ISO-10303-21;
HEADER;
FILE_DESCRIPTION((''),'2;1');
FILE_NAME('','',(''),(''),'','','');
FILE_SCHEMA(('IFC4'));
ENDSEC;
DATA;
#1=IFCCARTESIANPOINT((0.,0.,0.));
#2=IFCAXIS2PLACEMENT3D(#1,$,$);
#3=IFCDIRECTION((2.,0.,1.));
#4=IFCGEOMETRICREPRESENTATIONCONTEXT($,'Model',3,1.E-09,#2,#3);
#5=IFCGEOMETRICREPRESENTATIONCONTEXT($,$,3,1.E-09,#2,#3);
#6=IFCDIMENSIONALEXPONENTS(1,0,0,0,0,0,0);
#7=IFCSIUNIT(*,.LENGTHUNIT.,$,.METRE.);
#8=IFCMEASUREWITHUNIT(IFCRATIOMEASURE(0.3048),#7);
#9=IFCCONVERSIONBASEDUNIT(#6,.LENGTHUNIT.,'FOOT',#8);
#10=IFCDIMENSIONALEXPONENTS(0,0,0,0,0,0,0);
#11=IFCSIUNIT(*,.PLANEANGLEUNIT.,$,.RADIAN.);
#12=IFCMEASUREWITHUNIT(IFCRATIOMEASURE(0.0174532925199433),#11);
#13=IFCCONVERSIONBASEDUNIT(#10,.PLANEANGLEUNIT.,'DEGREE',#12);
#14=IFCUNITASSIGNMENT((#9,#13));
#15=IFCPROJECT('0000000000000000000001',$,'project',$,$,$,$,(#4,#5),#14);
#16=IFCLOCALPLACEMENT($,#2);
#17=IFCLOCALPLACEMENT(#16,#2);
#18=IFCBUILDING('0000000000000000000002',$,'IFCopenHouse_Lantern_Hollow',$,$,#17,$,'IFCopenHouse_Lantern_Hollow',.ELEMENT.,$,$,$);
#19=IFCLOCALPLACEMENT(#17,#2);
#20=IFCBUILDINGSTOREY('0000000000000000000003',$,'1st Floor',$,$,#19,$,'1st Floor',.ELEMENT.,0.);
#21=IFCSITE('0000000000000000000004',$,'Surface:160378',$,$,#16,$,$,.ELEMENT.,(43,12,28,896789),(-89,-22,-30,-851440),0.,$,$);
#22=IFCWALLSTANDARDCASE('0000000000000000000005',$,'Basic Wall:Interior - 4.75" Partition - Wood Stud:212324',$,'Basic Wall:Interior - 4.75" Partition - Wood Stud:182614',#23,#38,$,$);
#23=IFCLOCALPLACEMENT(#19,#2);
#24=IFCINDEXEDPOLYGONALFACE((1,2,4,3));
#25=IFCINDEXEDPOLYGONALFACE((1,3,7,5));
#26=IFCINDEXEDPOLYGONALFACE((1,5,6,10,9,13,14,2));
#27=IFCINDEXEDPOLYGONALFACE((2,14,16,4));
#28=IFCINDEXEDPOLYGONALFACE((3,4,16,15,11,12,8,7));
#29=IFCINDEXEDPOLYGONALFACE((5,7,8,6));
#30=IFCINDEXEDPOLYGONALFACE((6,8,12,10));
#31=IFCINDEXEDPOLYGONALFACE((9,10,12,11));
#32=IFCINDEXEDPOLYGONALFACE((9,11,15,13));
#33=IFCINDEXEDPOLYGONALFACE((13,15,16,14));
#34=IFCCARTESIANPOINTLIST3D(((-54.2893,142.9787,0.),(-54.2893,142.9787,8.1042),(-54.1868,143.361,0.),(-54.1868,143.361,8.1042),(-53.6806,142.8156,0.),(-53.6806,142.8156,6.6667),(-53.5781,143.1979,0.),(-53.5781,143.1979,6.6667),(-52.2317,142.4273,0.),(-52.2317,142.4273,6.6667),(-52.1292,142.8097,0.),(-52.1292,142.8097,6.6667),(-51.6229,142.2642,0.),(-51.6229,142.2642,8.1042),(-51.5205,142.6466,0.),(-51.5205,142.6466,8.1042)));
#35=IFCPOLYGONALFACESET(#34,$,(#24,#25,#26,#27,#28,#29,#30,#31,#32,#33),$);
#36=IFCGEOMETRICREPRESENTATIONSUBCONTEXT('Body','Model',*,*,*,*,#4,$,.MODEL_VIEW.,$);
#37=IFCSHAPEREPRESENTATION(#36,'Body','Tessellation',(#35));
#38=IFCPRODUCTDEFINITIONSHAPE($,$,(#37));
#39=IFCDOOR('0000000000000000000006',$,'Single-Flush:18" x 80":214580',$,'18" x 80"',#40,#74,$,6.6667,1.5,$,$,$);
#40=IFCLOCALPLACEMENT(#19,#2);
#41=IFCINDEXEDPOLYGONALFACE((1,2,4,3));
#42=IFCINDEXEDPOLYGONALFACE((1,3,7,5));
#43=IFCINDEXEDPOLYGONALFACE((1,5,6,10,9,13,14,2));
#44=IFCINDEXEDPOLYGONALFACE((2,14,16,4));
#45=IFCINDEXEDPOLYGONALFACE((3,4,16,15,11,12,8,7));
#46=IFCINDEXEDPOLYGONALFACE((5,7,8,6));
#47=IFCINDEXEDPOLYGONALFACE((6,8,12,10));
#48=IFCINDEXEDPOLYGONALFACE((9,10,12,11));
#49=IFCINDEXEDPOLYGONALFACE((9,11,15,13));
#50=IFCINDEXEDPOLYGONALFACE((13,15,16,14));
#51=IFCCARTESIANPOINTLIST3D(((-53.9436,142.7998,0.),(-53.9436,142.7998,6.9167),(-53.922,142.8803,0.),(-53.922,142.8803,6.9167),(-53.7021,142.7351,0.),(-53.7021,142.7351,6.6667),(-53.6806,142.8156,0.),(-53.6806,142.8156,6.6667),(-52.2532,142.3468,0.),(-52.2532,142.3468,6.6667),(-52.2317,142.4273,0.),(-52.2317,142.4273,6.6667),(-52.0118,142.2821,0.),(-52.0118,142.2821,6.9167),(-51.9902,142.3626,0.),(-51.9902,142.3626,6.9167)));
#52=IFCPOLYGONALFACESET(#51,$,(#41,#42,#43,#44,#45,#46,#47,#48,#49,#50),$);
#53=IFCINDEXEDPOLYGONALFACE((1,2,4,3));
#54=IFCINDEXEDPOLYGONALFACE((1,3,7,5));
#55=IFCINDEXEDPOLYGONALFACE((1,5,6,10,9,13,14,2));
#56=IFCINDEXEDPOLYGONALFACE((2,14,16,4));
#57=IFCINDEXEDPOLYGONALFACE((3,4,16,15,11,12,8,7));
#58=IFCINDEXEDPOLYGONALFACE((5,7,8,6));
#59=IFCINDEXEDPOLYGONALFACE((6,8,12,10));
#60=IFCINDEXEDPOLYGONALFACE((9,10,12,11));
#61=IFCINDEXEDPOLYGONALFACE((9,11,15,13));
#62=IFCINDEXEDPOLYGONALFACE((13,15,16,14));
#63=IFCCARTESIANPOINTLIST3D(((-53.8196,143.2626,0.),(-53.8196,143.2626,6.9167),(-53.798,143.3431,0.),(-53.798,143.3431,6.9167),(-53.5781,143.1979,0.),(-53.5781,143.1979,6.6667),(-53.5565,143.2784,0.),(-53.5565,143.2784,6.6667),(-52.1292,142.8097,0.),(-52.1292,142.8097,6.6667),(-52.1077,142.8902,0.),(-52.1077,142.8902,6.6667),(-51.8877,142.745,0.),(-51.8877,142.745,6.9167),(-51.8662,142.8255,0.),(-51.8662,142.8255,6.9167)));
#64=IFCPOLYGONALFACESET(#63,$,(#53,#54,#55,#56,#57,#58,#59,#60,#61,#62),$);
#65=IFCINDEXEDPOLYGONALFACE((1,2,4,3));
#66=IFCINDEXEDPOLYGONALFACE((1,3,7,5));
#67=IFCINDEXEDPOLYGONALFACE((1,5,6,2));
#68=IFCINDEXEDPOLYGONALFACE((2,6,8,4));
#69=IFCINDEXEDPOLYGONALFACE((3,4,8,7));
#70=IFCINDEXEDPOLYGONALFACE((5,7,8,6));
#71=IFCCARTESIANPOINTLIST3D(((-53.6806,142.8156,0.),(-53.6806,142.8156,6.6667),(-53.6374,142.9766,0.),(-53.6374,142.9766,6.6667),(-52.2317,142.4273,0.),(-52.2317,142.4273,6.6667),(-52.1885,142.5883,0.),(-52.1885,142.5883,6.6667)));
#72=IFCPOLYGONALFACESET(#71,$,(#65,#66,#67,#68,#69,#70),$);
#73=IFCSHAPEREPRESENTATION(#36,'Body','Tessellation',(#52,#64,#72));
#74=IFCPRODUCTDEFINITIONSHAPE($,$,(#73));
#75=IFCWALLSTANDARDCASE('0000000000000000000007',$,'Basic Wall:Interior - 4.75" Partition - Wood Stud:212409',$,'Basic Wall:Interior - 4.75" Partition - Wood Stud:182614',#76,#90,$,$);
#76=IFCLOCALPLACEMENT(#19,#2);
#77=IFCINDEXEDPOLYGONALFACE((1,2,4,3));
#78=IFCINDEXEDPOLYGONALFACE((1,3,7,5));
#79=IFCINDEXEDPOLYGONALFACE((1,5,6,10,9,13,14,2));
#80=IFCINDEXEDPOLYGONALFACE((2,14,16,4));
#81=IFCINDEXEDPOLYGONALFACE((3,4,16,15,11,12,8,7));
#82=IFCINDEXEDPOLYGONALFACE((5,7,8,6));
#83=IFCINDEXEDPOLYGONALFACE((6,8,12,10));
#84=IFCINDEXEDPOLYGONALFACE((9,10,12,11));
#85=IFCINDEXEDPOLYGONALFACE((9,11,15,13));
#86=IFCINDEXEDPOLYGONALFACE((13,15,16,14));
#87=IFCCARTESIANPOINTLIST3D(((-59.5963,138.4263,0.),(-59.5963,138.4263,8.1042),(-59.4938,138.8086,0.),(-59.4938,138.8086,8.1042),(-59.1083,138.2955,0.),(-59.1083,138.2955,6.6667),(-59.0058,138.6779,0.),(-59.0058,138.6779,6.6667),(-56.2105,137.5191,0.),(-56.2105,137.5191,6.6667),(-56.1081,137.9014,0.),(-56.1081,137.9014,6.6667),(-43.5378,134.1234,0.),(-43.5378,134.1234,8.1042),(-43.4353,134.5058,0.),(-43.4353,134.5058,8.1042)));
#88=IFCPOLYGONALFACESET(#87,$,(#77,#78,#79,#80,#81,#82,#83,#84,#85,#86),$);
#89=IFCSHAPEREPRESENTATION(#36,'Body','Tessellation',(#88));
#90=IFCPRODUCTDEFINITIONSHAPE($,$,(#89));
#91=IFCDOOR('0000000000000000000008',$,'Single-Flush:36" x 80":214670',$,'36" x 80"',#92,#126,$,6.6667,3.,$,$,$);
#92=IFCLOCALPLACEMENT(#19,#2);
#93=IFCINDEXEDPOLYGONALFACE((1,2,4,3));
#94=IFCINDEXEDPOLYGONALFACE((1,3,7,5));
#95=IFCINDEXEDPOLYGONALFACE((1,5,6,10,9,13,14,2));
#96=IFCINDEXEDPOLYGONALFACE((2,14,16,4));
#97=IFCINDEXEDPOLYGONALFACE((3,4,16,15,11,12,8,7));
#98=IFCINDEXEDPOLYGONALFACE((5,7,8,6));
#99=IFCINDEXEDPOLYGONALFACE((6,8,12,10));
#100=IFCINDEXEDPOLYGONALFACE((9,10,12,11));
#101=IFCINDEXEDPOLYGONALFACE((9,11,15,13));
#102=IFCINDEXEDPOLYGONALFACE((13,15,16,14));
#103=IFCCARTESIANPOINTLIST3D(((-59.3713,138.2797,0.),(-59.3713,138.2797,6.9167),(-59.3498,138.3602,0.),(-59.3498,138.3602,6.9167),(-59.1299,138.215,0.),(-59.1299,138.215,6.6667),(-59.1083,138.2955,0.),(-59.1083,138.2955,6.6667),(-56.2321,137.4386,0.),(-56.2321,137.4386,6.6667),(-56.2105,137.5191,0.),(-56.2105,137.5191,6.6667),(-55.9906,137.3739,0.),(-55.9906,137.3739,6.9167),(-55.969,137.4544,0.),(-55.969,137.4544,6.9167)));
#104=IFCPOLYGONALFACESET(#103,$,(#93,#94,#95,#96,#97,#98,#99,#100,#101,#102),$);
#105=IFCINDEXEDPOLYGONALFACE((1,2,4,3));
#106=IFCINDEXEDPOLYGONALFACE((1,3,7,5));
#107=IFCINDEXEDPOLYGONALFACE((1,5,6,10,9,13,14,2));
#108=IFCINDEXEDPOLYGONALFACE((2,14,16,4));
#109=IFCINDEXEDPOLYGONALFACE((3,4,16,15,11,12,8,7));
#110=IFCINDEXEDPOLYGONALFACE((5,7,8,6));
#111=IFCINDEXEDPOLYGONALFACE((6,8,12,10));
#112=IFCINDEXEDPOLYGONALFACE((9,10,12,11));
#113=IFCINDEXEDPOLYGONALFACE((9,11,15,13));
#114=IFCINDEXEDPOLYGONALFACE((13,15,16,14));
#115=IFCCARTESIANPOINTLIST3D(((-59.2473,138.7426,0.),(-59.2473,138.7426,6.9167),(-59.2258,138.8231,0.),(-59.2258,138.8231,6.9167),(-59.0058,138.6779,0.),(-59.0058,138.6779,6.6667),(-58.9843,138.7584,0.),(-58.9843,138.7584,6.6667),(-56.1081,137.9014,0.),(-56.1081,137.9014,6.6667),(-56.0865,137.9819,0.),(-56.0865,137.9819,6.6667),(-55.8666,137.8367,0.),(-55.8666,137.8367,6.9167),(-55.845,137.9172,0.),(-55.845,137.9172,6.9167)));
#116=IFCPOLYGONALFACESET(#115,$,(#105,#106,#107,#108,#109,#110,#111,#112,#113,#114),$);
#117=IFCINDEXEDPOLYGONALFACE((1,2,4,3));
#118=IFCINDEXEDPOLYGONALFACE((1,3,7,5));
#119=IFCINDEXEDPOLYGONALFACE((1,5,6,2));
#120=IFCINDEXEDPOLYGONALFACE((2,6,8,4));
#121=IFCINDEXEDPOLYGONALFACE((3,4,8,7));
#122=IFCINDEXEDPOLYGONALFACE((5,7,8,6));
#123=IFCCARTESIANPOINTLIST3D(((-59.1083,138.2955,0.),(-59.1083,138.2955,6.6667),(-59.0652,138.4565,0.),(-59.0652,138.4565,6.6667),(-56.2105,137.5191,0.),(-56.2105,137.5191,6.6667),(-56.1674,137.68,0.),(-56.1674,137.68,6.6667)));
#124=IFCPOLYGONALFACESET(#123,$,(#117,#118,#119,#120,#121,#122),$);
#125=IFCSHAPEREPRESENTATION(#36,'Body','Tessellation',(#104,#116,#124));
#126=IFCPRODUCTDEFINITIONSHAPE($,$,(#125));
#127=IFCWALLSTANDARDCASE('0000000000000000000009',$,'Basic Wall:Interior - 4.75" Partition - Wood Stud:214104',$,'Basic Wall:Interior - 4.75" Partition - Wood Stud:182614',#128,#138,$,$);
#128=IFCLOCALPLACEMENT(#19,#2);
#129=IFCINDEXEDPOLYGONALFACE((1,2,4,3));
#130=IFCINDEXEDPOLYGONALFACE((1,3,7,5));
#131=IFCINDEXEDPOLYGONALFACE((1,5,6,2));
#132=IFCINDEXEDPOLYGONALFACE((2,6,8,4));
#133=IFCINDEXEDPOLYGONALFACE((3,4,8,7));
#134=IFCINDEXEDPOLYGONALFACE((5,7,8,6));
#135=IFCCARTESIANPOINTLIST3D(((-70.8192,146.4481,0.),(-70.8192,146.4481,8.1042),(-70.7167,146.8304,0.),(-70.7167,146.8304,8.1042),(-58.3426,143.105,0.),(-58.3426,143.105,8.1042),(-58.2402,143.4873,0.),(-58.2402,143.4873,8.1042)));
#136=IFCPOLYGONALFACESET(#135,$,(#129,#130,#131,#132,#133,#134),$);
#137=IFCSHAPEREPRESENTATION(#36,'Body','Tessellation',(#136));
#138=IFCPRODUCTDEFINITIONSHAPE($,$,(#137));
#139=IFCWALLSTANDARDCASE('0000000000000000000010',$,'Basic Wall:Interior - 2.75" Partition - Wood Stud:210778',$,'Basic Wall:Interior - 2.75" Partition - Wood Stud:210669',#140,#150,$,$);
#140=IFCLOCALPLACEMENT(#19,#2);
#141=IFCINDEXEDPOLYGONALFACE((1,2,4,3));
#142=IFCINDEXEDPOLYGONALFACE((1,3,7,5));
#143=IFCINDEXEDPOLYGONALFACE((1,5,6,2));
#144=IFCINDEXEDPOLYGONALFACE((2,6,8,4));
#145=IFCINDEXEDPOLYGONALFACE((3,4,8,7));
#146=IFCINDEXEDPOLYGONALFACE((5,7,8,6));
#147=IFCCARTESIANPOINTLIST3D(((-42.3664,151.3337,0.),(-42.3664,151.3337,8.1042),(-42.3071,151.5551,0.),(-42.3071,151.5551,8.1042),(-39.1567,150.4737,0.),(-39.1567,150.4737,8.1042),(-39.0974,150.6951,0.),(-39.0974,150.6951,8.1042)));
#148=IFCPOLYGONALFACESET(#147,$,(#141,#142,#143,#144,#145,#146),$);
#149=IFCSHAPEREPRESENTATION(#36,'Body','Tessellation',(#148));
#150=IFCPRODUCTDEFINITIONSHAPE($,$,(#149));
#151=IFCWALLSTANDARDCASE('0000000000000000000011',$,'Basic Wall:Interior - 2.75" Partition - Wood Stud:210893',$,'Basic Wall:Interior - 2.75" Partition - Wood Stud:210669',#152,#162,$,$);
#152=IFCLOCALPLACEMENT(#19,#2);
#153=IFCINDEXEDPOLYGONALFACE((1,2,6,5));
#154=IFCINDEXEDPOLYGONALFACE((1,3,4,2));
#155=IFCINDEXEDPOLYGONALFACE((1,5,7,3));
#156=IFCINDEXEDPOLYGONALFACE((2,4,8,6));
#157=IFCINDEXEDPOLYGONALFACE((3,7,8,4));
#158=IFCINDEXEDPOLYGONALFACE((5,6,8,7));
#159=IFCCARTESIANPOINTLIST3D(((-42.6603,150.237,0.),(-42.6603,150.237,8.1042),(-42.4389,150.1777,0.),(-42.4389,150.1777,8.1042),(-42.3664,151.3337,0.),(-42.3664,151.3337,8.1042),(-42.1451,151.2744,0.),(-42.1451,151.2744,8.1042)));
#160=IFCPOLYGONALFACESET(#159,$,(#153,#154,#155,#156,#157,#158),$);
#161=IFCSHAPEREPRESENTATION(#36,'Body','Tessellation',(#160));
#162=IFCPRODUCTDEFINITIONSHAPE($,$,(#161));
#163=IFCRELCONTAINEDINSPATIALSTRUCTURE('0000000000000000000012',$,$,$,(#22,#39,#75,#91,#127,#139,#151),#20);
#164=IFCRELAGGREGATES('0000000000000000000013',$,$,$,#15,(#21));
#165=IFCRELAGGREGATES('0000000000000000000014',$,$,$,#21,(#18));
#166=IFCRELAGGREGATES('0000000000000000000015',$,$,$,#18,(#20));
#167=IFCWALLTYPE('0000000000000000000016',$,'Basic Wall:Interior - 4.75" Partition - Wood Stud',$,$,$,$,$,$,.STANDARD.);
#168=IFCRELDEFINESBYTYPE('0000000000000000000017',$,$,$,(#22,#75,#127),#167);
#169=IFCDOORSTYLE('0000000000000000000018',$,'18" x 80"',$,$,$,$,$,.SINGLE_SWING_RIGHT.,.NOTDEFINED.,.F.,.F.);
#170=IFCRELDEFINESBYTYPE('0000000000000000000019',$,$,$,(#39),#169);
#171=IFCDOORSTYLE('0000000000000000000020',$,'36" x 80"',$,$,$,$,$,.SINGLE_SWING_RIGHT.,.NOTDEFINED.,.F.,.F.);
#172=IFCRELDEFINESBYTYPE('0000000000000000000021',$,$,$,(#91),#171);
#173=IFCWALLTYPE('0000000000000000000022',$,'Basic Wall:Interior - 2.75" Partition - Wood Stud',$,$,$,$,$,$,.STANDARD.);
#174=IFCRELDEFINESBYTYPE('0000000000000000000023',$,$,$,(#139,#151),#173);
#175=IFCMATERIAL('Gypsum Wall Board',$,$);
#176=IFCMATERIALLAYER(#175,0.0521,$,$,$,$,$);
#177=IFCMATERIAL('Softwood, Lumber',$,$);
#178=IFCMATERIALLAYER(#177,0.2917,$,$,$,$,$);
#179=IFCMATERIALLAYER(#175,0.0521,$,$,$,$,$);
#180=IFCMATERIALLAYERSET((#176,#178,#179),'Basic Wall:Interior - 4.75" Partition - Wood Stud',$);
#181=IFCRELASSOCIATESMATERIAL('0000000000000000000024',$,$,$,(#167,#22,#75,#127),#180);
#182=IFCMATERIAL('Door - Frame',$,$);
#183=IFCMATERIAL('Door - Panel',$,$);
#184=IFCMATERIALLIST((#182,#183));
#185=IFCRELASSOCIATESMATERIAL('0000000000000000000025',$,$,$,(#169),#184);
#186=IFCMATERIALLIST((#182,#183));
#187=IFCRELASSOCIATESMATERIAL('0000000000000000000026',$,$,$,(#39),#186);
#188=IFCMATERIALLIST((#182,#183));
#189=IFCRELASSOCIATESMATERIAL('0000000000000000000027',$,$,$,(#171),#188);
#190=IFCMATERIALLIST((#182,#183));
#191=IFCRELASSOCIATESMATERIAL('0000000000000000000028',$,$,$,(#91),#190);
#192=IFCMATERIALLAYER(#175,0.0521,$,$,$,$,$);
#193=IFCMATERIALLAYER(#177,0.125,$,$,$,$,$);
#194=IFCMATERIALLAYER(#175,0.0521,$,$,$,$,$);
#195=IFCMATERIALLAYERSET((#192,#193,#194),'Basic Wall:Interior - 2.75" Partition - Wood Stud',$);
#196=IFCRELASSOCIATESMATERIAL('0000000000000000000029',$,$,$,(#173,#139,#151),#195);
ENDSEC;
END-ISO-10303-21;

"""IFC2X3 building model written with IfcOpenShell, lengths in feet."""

from ifc_helpers import new_model, entity, si_unit, converted_unit, direction, frame, frame_2d, origin, place, context, subcontext, project, spatial, polyline, rectangle, outline, extrude, source, transform, mapped, material, material_list, layer, layer_set, layer_usage, type_object, type_shapes, element, fill, save


model = new_model("IFC2X3")

# Units and contexts
model_context = context("Model", 3, precision=1e-09, world=origin(), true_north=direction((2.0, 0.0, 1.0)))
context_of_model = context(None, 3, precision=1e-09, world=origin(), true_north=direction((2.0, 0.0, 1.0)))
body_context = subcontext(model_context, "Body", "Model", "MODEL_VIEW")
ifc_project = project(units=[converted_unit("LENGTHUNIT", "FOOT", entity("IfcRatioMeasure", 0.3048), si_unit("LENGTHUNIT", "METRE"), dimensions=[1, 0, 0, 0, 0, 0, 0]), converted_unit("PLANEANGLEUNIT", "DEGREE", entity("IfcRatioMeasure", 0.0174532925199433), si_unit("PLANEANGLEUNIT", "RADIAN"), dimensions=[0, 0, 0, 0, 0, 0, 0])], contexts=[model_context, context_of_model])

# Site, building, storey
site_placement = place(None, origin())
site = spatial("IfcSite", under=ifc_project, at=site_placement, Name="Surface:160378", CompositionType="ELEMENT", RefLatitude=(43, 12, 28, 896789), RefLongitude=(-89, -22, -30, -851440), RefElevation=0.0)
building_placement = place(site_placement, origin())
building = spatial("IfcBuilding", under=site, at=building_placement, Name="IFCopenHouse_Lantern_Hollow", LongName="IFCopenHouse_Lantern_Hollow", CompositionType="ELEMENT")
storey_placement = place(building_placement, origin())
storey = spatial("IfcBuildingStorey", under=building, at=storey_placement, Name="1st Floor", LongName="1st Floor", CompositionType="ELEMENT", Elevation=0.0)

# Shared definitions
ifc_material_1 = material(Name="Gypsum Wall Board")
ifc_layer_1 = layer(ifc_material_1, 0.0521)
ifc_material_2 = material(Name="Softwood, Lumber")
ifc_layer_2 = layer(ifc_material_2, 0.2917)
ifc_layer_3 = layer(ifc_material_1, 0.0521)
ifc_layer_set_1 = layer_set([ifc_layer_1, ifc_layer_2, ifc_layer_3], Name="Basic Wall:Interior - 4.75\" Partition - Wood Stud")
wall_type_1 = type_object("IfcWallType", Name="Basic Wall:Interior - 4.75\" Partition - Wood Stud", PredefinedType="STANDARD", material=ifc_layer_set_1)

# Shared definitions
ifc_material_3 = material(Name="Door - Panel")
ifc_material_4 = material(Name="Door - Frame")

# Walls, openings, doors
ifc_layer_usage_1 = layer_usage(ifc_layer_set_1, "AXIS2", "NEGATIVE", 0.1979)
wall_1_placement = place(storey_placement, frame((-51.5717, 142.4554, 0.0), z_axis=(0.0, 0.0, 1.0), x_axis=(-0.965926, 0.258819, 0.0)))
wall_1 = element("IfcWallStandardCase", 1, at=wall_1_placement, inside=storey, type_object=wall_type_1, material=ifc_layer_usage_1, Name="Basic Wall:Interior - 4.75\" Partition - Wood Stud:212324", ObjectType="Basic Wall:Interior - 4.75\" Partition - Wood Stud:182614", context=body_context, shape_type="SweptSolid", body=[
    extrude(rectangle(XDim=2.7604, YDim=0.3958, at=frame_2d((1.3802, 0.0), x_axis=(-1.0, 0.0))), origin(), (0.0, 0.0, 1.0), 8.1042),
])
opening_1_placement = place(wall_1_placement, frame((0.6302, -0.1979, 0.0)))
opening_1 = element("IfcOpeningElement", 2, at=opening_1_placement, cuts=wall_1, ObjectType="Opening", context=body_context, shape_type="SweptSolid", body=[
    extrude(rectangle(XDim=1.5, YDim=6.6667, at=frame_2d((3.3333, 0.75), x_axis=(0.0, 1.0))), frame((0.0, 0.0, 0.0), z_axis=(0.0, 1.0, 0.0), x_axis=(0.0, 0.0, 1.0)), (0.0, 0.0, 1.0), 0.3958),
])
ifc_material_list_1 = material_list([ifc_material_4, ifc_material_3])
ifc_material_list_2 = material_list([ifc_material_4, ifc_material_3])
door_style_1 = type_object("IfcDoorStyle", Name="18\" x 80\"", ConstructionType="NOTDEFINED", OperationType="SINGLE_SWING_RIGHT", ParameterTakesPrecedence=False, Sizeable=False, material=ifc_material_list_2)
shared_shape_1 = source(origin(), body_context, "Body", "SweptSolid", [
    extrude(outline(polyline([(-1.0, -3.5208), (1.0, -3.5208), (1.0, 3.3958), (0.75, 3.3958), (0.75, -3.2708), (-0.75, -3.2708), (-0.75, 3.3958), (-1.0, 3.3958), (-1.0, -3.5208)])), frame((0.75, 0.3958, 3.3958), z_axis=(0.0, 1.0, 0.0), x_axis=(1.0, 0.0, 0.0)), (0.0, 0.0, 1.0), 0.0833),
    extrude(outline(polyline([(-3.5208, -1.0), (3.3958, -1.0), (3.3958, -0.75), (-3.2708, -0.75), (-3.2708, 0.75), (3.3958, 0.75), (3.3958, 1.0), (-3.5208, 1.0), (-3.5208, -1.0)])), frame((0.75, -0.0833, 3.3958), z_axis=(0.0, 1.0, 0.0), x_axis=(0.0, 0.0, -1.0)), (0.0, 0.0, 1.0), 0.0833),
    extrude(rectangle(XDim=0.1667, YDim=1.5, at=frame_2d((0.0, 0.0), x_axis=(1.0, 0.0))), frame((0.75, 0.3125, 0.0), z_axis=(0.0, 0.0, 1.0), x_axis=(0.0, 1.0, 0.0)), (0.0, 0.0, 1.0), 6.6667),
])
type_shapes(door_style_1, [shared_shape_1])
door_1_placement = place(storey_placement, frame((-52.1292, 142.8097, 0.0), z_axis=(0.0, 0.0, 1.0), x_axis=(-0.965926, 0.258819, 0.0)))
door_1 = element("IfcDoor", 3, at=door_1_placement, inside=storey, type_object=door_style_1, material=ifc_material_list_1, Name="Single-Flush:18\" x 80\":214580", ObjectType="18\" x 80\"", OverallHeight=6.6667, OverallWidth=1.5, context=body_context, shape_type="MappedRepresentation", body=[
    mapped(shared_shape_1, transform((0.0, 0.0, 0.0), scale=1.0)),
])
fill(opening_1, door_1)
ifc_layer_usage_2 = layer_usage(ifc_layer_set_1, "AXIS2", "NEGATIVE", 0.1979)
wall_2_placement = place(storey_placement, frame((-43.4865, 134.3146, 0.0), z_axis=(0.0, 0.0, 1.0), x_axis=(-0.965926, 0.258819, 0.0)))
wall_2 = element("IfcWallStandardCase", 4, at=wall_2_placement, inside=storey, type_object=wall_type_1, material=ifc_layer_usage_2, Name="Basic Wall:Interior - 4.75\" Partition - Wood Stud:212409", ObjectType="Basic Wall:Interior - 4.75\" Partition - Wood Stud:182614", context=body_context, shape_type="SweptSolid", body=[
    extrude(rectangle(XDim=16.625, YDim=0.3958, at=frame_2d((8.3125, 0.0), x_axis=(-1.0, 0.0))), origin(), (0.0, 0.0, 1.0), 8.1042),
])
opening_2_placement = place(wall_2_placement, frame((13.1198, -0.1979, 0.0)))
opening_2 = element("IfcOpeningElement", 5, at=opening_2_placement, cuts=wall_2, ObjectType="Opening", context=body_context, shape_type="SweptSolid", body=[
    extrude(rectangle(XDim=3.0, YDim=6.6667, at=frame_2d((3.3333, 1.5), x_axis=(0.0, 1.0))), frame((0.0, 0.0, 0.0), z_axis=(0.0, 1.0, 0.0), x_axis=(0.0, 0.0, 1.0)), (0.0, 0.0, 1.0), 0.3958),
])
ifc_material_list_3 = material_list([ifc_material_4, ifc_material_3])
ifc_material_list_4 = material_list([ifc_material_4, ifc_material_3])
door_style_2 = type_object("IfcDoorStyle", Name="36\" x 80\"", ConstructionType="NOTDEFINED", OperationType="SINGLE_SWING_RIGHT", ParameterTakesPrecedence=False, Sizeable=False, material=ifc_material_list_4)
shared_shape_2 = source(origin(), body_context, "Body", "SweptSolid", [
    extrude(outline(polyline([(-1.75, -3.5208), (1.75, -3.5208), (1.75, 3.3958), (1.5, 3.3958), (1.5, -3.2708), (-1.5, -3.2708), (-1.5, 3.3958), (-1.75, 3.3958), (-1.75, -3.5208)])), frame((1.5, 0.3958, 3.3958), z_axis=(0.0, 1.0, 0.0), x_axis=(1.0, 0.0, 0.0)), (0.0, 0.0, 1.0), 0.0833),
    extrude(outline(polyline([(-3.5208, -1.75), (3.3958, -1.75), (3.3958, -1.5), (-3.2708, -1.5), (-3.2708, 1.5), (3.3958, 1.5), (3.3958, 1.75), (-3.5208, 1.75), (-3.5208, -1.75)])), frame((1.5, -0.0833, 3.3958), z_axis=(0.0, 1.0, 0.0), x_axis=(0.0, 0.0, -1.0)), (0.0, 0.0, 1.0), 0.0833),
    extrude(rectangle(XDim=0.1667, YDim=3.0, at=frame_2d((0.0, 0.0), x_axis=(1.0, 0.0))), frame((1.5, 0.3125, 0.0), z_axis=(0.0, 0.0, 1.0), x_axis=(0.0, 1.0, 0.0)), (0.0, 0.0, 1.0), 6.6667),
])
type_shapes(door_style_2, [shared_shape_2])
door_2_placement = place(storey_placement, frame((-56.1081, 137.9014, 0.0), z_axis=(0.0, 0.0, 1.0), x_axis=(-0.965926, 0.258819, 0.0)))
door_2 = element("IfcDoor", 6, at=door_2_placement, inside=storey, type_object=door_style_2, material=ifc_material_list_3, Name="Single-Flush:36\" x 80\":214670", ObjectType="36\" x 80\"", OverallHeight=6.6667, OverallWidth=3.0, context=body_context, shape_type="MappedRepresentation", body=[
    mapped(shared_shape_2, transform((0.0, 0.0, 0.0), scale=1.0)),
])
fill(opening_2, door_2)

# Wall
ifc_layer_usage_3 = layer_usage(ifc_layer_set_1, "AXIS2", "NEGATIVE", 0.1979)
wall_3_placement = place(storey_placement, frame((-58.2914, 143.2962, 0.0), z_axis=(0.0, 0.0, 1.0), x_axis=(-0.965926, 0.258819, 0.0)))
element("IfcWallStandardCase", 7, at=wall_3_placement, inside=storey, type_object=wall_type_1, material=ifc_layer_usage_3, Name="Basic Wall:Interior - 4.75\" Partition - Wood Stud:214104", ObjectType="Basic Wall:Interior - 4.75\" Partition - Wood Stud:182614", context=body_context, shape_type="SweptSolid", body=[
    extrude(rectangle(XDim=12.9167, YDim=0.3958, at=frame_2d((6.4583, 0.0), x_axis=(-1.0, 0.0))), origin(), (0.0, 0.0, 1.0), 8.1042),
])

# Walls
ifc_layer_4 = layer(ifc_material_1, 0.0521)
ifc_layer_5 = layer(ifc_material_2, 0.125)
ifc_layer_6 = layer(ifc_material_1, 0.0521)
ifc_layer_set_2 = layer_set([ifc_layer_4, ifc_layer_5, ifc_layer_6], Name="Basic Wall:Interior - 2.75\" Partition - Wood Stud")
ifc_layer_usage_4 = layer_usage(ifc_layer_set_2, "AXIS2", "NEGATIVE", 0.1146)
wall_type_2 = type_object("IfcWallType", Name="Basic Wall:Interior - 2.75\" Partition - Wood Stud", PredefinedType="STANDARD", material=ifc_layer_set_2)
wall_4_placement = place(storey_placement, frame((-42.3368, 151.4444, 0.0), z_axis=(0.0, 0.0, 1.0), x_axis=(0.965926, -0.258819, 0.0)))
element("IfcWallStandardCase", 8, at=wall_4_placement, inside=storey, type_object=wall_type_2, material=ifc_layer_usage_4, Name="Basic Wall:Interior - 2.75\" Partition - Wood Stud:210778", ObjectType="Basic Wall:Interior - 2.75\" Partition - Wood Stud:210669", context=body_context, shape_type="SweptSolid", body=[
    extrude(rectangle(XDim=3.3229, YDim=0.2292, at=frame_2d((1.6615, 0.0), x_axis=(-1.0, 0.0))), origin(), (0.0, 0.0, 1.0), 8.1042),
])
ifc_layer_usage_5 = layer_usage(ifc_layer_set_2, "AXIS2", "NEGATIVE", 0.1146)
wall_5_placement = place(storey_placement, frame((-42.5496, 150.2074, 0.0), z_axis=(0.0, 0.0, 1.0), x_axis=(0.258819, 0.965926, 0.0)))
element("IfcWallStandardCase", 9, at=wall_5_placement, inside=storey, type_object=wall_type_2, material=ifc_layer_usage_5, Name="Basic Wall:Interior - 2.75\" Partition - Wood Stud:210893", ObjectType="Basic Wall:Interior - 2.75\" Partition - Wood Stud:210669", context=body_context, shape_type="SweptSolid", body=[
    extrude(rectangle(XDim=1.1354, YDim=0.2292, at=frame_2d((0.5677, 0.0), x_axis=(-1.0, 0.0))), origin(), (0.0, 0.0, 1.0), 8.1042),
])

save(model, "model.ifc")
